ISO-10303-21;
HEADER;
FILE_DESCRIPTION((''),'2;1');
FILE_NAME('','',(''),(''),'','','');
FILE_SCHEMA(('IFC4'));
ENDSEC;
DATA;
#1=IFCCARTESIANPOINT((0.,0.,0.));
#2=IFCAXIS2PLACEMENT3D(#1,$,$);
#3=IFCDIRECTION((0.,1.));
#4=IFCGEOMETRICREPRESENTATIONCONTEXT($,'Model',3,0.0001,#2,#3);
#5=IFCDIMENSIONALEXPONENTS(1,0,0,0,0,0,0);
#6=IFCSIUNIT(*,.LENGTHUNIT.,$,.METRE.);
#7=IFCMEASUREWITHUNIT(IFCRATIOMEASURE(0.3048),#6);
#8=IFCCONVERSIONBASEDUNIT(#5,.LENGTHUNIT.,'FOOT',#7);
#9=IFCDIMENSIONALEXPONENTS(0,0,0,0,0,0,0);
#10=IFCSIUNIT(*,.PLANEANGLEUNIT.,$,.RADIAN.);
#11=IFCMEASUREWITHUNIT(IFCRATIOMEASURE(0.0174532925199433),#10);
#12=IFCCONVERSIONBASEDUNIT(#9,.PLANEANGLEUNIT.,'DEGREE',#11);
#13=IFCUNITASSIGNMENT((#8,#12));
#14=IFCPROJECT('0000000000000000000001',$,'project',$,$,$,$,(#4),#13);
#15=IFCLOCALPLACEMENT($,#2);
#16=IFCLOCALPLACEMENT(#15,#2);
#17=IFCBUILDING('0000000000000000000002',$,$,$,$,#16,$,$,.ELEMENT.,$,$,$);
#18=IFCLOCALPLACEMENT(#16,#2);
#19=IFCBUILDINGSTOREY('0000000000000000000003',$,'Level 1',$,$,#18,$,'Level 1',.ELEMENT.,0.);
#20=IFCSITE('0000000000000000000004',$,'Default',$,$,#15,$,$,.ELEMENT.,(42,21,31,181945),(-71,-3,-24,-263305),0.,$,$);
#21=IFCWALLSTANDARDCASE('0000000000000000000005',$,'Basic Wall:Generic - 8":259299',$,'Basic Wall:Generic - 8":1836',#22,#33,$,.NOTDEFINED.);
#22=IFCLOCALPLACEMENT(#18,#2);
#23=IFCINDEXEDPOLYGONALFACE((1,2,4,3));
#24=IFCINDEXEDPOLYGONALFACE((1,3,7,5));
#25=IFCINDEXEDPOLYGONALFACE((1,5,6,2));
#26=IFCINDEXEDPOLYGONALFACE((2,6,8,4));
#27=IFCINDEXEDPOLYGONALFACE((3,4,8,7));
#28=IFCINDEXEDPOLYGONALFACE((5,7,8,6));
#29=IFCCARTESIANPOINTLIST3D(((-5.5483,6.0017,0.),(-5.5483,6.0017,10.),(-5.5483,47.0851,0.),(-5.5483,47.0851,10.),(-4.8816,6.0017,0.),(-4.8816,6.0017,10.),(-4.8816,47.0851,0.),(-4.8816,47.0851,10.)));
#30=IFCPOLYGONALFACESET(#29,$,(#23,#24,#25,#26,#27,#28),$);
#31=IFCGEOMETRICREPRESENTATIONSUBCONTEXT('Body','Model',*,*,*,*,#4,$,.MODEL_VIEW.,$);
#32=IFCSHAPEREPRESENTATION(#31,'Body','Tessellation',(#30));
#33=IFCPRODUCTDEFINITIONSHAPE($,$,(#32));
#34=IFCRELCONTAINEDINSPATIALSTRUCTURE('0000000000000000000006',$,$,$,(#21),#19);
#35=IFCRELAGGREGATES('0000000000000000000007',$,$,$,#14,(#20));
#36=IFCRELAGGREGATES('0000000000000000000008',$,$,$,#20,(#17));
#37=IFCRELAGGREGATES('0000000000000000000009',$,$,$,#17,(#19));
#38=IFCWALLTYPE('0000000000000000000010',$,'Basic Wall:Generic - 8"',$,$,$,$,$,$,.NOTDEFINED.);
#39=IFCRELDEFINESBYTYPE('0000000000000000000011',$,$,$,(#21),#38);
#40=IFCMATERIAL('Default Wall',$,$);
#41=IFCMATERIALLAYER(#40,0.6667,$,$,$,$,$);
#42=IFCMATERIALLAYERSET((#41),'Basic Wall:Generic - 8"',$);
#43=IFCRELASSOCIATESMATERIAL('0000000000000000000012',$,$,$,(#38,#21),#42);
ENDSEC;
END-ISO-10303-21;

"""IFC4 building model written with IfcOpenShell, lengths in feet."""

from ifc_helpers import new_model, entity, si_unit, converted_unit, direction, frame, frame_2d, origin, place, context, subcontext, project, spatial, rectangle, extrude, material, layer, layer_set, layer_usage, type_object, element, save


model = new_model("IFC4")

# Units and contexts
model_context = context("Model", 3, precision=0.0001, world=origin(), true_north=direction((0.0, 1.0)))
body_context = subcontext(model_context, "Body", "Model", "MODEL_VIEW")
ifc_project = project(units=[converted_unit("LENGTHUNIT", "FOOT", entity("IfcRatioMeasure", 0.3048), si_unit("LENGTHUNIT", "METRE"), dimensions=[1, 0, 0, 0, 0, 0, 0]), converted_unit("PLANEANGLEUNIT", "DEGREE", entity("IfcRatioMeasure", 0.0174532925199433), si_unit("PLANEANGLEUNIT", "RADIAN"), dimensions=[0, 0, 0, 0, 0, 0, 0])], contexts=[model_context])

# Site, building, storey
site_placement = place(None, origin())
site = spatial("IfcSite", under=ifc_project, at=site_placement, Name="Default", CompositionType="ELEMENT", RefLatitude=(42, 21, 31, 181945), RefLongitude=(-71, -3, -24, -263305), RefElevation=0.0)
building_placement = place(site_placement, origin())
building = spatial("IfcBuilding", under=site, at=building_placement, CompositionType="ELEMENT")
storey_placement = place(building_placement, origin())
storey = spatial("IfcBuildingStorey", under=building, at=storey_placement, Name="Level 1", LongName="Level 1", CompositionType="ELEMENT", Elevation=0.0)

# Wall
ifc_material_1 = material(Name="Default Wall")
ifc_layer = layer(ifc_material_1, 0.6667)
ifc_layer_set = layer_set([ifc_layer], Name="Basic Wall:Generic - 8\"")
ifc_layer_usage = layer_usage(ifc_layer_set, "AXIS2", "NEGATIVE", 0.3333)
wall_type = type_object("IfcWallType", Name="Basic Wall:Generic - 8\"", PredefinedType="NOTDEFINED", material=ifc_layer_set)
wall_placement = place(storey_placement, frame((-5.215, 47.0851, 0.0), z_axis=(0.0, 0.0, 1.0), x_axis=(0.0, -1.0, 0.0)))
element("IfcWallStandardCase", 1, at=wall_placement, inside=storey, type_object=wall_type, material=ifc_layer_usage, Name="Basic Wall:Generic - 8\":259299", ObjectType="Basic Wall:Generic - 8\":1836", PredefinedType="NOTDEFINED", context=body_context, shape_type="SweptSolid", body=[
    extrude(rectangle(XDim=41.0834, YDim=0.6667, at=frame_2d((20.5417, 0.0), x_axis=(-1.0, 0.0))), origin(), (0.0, 0.0, 1.0), 10.0),
])

save(model, "model.ifc")
